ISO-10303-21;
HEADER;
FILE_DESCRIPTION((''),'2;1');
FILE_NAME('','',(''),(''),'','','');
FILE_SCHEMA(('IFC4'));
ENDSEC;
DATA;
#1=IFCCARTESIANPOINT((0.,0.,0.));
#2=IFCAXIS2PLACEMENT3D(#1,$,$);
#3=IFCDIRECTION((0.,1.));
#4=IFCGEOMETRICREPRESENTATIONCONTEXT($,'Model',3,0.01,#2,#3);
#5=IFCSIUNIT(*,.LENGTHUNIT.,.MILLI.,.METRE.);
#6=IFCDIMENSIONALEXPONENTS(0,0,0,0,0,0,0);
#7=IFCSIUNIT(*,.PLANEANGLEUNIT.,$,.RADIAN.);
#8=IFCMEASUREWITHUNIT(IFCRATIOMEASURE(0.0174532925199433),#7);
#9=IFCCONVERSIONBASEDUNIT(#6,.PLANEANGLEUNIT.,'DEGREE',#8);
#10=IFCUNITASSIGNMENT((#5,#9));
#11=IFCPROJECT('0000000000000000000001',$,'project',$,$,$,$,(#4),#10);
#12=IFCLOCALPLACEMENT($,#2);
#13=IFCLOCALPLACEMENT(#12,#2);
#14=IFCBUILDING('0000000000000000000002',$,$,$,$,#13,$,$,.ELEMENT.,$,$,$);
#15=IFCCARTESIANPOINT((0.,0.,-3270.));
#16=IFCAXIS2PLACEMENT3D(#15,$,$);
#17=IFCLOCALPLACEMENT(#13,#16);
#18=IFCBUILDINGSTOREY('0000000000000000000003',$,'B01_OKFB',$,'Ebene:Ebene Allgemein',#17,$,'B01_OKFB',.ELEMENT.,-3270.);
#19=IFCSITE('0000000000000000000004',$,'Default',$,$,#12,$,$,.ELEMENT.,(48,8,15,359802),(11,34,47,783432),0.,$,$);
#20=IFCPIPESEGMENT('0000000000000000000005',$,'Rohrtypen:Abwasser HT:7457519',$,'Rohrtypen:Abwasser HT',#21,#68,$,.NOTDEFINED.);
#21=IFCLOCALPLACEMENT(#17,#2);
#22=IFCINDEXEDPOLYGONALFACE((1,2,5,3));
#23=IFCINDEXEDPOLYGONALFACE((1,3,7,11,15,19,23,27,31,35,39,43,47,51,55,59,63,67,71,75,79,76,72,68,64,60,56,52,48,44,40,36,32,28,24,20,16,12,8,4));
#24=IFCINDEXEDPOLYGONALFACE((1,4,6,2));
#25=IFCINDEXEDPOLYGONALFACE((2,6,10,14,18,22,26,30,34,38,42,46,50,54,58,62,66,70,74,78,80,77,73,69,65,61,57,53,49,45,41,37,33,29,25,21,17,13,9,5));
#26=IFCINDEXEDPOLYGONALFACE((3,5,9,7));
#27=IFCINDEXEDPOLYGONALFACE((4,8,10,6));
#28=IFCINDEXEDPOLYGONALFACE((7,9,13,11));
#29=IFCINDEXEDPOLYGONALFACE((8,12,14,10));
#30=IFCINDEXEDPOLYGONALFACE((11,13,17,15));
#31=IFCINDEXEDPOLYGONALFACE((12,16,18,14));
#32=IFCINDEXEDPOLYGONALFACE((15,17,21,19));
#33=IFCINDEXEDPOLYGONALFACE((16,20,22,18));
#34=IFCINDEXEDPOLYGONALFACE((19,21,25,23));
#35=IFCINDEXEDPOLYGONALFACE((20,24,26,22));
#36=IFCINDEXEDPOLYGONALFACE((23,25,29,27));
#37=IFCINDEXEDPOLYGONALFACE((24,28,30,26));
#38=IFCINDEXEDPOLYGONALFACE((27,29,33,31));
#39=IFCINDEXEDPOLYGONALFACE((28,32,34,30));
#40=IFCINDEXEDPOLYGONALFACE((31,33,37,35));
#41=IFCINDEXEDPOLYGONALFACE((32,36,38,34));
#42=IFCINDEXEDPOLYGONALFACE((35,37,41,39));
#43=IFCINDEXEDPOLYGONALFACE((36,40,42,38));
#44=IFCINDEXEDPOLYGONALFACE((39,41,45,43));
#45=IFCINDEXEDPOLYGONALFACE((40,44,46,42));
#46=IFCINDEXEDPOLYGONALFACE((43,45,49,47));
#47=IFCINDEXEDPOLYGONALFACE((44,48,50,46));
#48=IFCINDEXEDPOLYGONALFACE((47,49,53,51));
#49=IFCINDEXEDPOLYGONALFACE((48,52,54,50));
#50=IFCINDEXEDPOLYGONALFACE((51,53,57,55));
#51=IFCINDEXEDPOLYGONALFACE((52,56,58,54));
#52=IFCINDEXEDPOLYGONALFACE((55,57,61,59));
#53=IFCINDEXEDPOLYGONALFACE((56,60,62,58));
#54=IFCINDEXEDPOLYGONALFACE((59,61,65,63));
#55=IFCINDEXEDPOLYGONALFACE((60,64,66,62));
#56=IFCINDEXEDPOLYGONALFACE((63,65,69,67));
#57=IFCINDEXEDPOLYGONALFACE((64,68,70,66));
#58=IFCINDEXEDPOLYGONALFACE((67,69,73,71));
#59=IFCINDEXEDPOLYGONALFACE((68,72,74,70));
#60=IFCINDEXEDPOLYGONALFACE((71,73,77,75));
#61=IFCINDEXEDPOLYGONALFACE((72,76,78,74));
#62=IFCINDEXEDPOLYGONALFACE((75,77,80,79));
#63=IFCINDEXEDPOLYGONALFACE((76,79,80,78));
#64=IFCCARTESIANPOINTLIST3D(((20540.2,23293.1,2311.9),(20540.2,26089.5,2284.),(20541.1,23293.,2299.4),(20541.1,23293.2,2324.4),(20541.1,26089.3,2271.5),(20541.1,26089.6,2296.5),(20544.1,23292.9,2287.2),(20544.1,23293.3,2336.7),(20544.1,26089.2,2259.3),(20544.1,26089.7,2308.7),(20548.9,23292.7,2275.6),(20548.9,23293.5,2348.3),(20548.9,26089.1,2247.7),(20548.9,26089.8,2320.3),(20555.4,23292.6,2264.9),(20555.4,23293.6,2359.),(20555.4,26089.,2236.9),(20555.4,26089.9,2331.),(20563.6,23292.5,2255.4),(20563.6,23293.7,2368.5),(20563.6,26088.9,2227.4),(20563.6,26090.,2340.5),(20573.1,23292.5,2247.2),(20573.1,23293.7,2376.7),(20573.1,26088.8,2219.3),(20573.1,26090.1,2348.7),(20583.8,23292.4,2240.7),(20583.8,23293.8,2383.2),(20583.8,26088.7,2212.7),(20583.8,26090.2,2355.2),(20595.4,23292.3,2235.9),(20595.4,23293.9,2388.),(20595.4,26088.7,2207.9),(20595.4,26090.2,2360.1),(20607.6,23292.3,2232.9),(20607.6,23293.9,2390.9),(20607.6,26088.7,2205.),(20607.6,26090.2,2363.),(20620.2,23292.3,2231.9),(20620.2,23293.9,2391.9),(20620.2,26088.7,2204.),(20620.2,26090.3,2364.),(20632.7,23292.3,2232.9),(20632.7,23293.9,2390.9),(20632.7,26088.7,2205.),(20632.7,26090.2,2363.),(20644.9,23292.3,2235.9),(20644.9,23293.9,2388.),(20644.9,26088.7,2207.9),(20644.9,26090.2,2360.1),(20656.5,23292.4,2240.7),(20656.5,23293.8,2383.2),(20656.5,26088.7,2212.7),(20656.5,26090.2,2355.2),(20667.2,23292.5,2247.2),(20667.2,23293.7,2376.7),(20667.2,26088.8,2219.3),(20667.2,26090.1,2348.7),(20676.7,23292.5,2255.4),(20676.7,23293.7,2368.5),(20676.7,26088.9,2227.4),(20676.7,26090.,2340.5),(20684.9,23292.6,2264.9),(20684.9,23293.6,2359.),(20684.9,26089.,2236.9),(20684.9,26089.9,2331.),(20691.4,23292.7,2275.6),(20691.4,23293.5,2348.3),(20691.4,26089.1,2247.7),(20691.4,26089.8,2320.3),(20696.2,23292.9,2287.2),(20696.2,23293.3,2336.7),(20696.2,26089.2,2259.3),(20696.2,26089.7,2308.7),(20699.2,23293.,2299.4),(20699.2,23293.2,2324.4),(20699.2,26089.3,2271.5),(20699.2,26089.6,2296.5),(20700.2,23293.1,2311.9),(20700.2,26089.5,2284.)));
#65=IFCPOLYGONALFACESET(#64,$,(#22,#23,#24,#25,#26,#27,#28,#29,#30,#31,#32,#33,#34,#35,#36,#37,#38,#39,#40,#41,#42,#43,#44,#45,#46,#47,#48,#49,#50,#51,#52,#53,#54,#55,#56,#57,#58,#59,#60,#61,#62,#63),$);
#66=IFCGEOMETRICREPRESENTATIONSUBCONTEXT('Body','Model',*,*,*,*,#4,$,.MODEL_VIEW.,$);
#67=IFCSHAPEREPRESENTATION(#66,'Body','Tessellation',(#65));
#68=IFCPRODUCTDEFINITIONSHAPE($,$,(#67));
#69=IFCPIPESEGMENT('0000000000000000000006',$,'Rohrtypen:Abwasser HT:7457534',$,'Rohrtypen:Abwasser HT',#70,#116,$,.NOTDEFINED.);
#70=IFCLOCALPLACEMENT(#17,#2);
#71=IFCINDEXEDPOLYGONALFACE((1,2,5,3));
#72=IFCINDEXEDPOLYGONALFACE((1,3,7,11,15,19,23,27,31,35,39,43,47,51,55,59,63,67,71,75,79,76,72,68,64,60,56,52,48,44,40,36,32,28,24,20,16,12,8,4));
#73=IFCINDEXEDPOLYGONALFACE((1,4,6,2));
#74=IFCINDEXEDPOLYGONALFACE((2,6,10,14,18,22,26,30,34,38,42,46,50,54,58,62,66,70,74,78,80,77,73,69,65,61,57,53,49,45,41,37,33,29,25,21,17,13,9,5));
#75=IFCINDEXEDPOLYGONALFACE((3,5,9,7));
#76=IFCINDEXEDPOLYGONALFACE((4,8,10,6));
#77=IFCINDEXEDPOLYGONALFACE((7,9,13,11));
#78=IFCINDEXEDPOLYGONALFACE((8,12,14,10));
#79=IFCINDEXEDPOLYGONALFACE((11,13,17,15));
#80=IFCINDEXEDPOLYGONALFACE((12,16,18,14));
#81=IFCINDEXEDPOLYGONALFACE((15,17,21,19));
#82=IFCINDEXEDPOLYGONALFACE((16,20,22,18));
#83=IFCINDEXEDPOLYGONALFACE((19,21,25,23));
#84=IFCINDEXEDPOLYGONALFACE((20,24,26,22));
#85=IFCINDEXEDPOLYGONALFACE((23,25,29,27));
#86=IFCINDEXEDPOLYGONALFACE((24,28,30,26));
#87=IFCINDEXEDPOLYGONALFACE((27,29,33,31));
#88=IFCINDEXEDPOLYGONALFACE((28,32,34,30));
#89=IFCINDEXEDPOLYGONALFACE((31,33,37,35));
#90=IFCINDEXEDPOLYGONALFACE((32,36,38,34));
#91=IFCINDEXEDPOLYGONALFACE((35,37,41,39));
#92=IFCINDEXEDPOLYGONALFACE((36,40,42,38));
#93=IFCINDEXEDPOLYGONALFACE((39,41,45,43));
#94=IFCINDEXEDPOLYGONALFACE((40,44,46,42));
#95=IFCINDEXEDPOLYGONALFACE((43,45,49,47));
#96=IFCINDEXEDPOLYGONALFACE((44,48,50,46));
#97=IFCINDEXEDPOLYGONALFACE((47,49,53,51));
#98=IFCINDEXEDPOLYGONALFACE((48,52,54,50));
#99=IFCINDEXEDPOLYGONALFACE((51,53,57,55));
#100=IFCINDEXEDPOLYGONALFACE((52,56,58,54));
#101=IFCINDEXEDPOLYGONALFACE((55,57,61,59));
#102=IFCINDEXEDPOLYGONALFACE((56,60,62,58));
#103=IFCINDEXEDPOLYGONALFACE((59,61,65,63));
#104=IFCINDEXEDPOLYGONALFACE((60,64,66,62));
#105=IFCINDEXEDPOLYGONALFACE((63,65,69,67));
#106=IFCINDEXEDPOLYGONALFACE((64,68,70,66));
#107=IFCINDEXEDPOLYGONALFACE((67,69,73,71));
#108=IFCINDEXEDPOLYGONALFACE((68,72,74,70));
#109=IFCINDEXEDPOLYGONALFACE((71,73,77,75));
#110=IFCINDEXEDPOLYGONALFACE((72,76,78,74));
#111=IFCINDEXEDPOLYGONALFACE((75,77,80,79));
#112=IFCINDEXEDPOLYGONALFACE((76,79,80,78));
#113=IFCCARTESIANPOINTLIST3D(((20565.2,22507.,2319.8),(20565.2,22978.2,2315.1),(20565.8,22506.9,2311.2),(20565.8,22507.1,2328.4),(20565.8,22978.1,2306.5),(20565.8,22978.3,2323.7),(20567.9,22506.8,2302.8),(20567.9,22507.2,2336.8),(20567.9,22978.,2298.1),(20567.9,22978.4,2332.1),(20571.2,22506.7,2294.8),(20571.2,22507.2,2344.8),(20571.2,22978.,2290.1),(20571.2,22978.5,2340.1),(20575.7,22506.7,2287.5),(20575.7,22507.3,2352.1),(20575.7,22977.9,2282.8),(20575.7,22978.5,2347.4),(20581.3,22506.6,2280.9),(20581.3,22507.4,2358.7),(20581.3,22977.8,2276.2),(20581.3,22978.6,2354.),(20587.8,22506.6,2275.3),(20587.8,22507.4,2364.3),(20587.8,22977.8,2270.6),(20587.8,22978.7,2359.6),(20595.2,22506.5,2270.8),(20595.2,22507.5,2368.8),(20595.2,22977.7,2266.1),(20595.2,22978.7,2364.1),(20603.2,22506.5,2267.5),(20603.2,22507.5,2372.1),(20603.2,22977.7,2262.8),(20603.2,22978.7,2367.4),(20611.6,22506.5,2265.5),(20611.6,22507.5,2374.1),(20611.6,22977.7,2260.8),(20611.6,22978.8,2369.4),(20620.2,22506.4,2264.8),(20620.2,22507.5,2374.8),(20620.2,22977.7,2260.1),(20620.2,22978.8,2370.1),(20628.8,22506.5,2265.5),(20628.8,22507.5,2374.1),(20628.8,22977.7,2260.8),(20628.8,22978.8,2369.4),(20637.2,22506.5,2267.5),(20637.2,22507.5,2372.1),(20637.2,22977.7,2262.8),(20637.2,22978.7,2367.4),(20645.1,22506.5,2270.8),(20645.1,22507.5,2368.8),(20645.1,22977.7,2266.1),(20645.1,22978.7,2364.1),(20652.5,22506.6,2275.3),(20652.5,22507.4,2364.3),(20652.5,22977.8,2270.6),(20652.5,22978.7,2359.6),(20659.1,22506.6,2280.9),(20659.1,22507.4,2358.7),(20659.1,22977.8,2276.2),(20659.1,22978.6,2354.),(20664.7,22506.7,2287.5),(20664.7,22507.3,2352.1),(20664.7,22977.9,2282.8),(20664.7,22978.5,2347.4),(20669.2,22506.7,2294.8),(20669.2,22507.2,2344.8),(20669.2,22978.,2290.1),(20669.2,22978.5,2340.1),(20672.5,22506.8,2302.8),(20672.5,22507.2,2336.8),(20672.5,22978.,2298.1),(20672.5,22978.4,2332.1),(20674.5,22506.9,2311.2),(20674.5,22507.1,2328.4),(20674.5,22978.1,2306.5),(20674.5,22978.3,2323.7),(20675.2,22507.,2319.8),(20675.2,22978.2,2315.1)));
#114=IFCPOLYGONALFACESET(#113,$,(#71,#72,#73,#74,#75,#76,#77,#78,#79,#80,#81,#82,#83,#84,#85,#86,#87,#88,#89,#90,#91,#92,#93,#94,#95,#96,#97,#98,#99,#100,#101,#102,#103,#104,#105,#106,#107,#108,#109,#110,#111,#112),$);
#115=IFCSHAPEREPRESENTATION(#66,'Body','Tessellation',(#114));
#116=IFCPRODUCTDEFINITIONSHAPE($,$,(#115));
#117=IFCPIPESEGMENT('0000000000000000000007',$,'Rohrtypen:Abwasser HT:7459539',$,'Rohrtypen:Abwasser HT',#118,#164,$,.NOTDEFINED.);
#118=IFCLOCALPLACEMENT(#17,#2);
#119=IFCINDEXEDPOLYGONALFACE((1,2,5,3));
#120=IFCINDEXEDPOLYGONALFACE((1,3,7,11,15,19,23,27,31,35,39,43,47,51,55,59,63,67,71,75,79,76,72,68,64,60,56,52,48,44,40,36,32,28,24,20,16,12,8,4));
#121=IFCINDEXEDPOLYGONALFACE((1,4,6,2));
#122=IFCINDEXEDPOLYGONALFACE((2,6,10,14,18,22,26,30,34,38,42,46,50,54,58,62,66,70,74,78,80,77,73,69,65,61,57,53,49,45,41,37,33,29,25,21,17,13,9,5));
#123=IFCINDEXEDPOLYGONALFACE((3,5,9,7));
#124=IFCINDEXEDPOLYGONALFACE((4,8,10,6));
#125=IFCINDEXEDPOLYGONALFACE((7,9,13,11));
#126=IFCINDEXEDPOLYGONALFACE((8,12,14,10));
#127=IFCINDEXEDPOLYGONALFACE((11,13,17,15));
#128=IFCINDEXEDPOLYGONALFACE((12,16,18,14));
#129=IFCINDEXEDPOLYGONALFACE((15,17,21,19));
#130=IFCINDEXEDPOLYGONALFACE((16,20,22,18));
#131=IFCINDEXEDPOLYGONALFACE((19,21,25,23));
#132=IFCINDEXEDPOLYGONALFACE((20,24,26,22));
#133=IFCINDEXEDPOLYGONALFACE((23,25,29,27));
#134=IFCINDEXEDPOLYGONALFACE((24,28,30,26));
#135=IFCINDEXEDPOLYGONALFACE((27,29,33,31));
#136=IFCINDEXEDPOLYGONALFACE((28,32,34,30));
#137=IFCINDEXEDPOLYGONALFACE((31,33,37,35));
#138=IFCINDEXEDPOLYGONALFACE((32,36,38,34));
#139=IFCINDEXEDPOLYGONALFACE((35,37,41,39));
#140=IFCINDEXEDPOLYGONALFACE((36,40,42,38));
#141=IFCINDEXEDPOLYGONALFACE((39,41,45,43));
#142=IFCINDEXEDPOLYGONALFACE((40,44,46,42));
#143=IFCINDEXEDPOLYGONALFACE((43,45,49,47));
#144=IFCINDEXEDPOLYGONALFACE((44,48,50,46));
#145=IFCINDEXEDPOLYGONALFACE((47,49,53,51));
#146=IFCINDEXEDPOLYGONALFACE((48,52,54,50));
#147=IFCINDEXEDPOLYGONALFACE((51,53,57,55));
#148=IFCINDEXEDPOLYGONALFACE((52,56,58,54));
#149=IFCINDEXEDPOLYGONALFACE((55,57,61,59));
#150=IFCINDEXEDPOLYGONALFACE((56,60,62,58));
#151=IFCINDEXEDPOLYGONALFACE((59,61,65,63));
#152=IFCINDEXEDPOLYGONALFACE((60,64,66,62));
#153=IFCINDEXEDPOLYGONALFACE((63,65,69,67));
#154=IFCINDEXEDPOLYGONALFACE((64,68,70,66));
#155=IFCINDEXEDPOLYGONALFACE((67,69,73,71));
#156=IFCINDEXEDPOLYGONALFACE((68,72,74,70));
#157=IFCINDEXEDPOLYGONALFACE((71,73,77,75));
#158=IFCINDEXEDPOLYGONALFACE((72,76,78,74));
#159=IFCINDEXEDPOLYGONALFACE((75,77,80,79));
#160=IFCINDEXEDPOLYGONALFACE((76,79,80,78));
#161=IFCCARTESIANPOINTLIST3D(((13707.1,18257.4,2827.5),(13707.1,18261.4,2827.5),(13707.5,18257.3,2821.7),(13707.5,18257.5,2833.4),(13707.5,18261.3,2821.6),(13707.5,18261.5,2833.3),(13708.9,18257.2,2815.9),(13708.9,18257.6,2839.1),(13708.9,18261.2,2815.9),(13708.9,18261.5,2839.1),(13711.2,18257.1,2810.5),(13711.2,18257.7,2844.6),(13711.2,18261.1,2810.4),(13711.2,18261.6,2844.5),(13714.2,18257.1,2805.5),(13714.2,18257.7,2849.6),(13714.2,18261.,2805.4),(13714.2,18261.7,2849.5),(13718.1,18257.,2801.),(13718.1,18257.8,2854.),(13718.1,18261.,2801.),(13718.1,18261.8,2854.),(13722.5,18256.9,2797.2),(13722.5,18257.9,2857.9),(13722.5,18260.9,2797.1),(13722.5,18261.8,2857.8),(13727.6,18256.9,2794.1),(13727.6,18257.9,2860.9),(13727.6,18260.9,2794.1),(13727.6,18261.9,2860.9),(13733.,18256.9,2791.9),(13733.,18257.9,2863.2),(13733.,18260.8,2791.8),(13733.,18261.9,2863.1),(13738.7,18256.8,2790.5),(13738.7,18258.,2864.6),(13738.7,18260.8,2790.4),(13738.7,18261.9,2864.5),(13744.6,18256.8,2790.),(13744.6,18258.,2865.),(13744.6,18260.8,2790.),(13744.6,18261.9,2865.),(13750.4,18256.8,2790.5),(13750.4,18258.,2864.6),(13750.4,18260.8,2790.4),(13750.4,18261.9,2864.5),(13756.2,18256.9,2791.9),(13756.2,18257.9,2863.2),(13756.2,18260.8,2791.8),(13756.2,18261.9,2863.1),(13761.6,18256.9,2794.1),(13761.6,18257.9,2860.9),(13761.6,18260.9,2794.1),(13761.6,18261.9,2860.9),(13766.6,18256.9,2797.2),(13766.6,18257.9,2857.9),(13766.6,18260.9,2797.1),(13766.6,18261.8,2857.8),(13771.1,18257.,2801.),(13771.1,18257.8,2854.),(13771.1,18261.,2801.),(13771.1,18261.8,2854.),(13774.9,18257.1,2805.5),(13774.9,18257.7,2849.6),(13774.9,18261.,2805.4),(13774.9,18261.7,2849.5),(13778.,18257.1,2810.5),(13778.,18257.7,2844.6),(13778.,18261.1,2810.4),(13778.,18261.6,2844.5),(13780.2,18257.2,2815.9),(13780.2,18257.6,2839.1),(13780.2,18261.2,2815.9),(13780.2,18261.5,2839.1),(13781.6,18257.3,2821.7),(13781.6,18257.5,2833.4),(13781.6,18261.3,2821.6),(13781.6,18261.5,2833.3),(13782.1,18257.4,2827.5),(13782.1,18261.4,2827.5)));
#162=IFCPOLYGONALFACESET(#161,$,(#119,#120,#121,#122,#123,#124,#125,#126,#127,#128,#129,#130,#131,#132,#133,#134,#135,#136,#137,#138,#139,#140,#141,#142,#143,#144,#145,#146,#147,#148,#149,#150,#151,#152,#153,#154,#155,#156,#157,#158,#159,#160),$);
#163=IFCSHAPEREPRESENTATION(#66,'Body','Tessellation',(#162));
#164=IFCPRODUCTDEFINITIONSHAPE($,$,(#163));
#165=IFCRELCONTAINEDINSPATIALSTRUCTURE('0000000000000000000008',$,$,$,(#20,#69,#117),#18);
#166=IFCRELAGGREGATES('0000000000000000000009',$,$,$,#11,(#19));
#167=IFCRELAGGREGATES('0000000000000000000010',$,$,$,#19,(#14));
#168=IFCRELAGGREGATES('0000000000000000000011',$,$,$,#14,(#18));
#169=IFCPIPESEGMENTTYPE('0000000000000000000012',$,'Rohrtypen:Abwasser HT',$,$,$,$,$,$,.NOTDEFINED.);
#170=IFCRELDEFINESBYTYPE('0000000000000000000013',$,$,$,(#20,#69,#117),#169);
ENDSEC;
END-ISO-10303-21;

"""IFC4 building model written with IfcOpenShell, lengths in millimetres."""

from ifc_helpers import new_model, entity, si_unit, converted_unit, direction, frame, origin, place, context, subcontext, project, spatial, indexed_curve, outline, extrude, type_object, element, save


model = new_model("IFC4")

# Units and contexts
model_context = context("Model", 3, precision=0.01, world=origin(), true_north=direction((0.0, 1.0)))
body_context = subcontext(model_context, "Body", "Model", "MODEL_VIEW")
ifc_project = project(units=[si_unit("LENGTHUNIT", "METRE", prefix="MILLI"), converted_unit("PLANEANGLEUNIT", "DEGREE", entity("IfcRatioMeasure", 0.0174532925199433), si_unit("PLANEANGLEUNIT", "RADIAN"), dimensions=[0, 0, 0, 0, 0, 0, 0])], contexts=[model_context])

# Site, building, storey
site_placement = place(None, origin())
site = spatial("IfcSite", under=ifc_project, at=site_placement, Name="Default", CompositionType="ELEMENT", RefLatitude=(48, 8, 15, 359802), RefLongitude=(11, 34, 47, 783432), RefElevation=0.0)
building_placement = place(site_placement, origin())
building = spatial("IfcBuilding", under=site, at=building_placement, CompositionType="ELEMENT")
storey_placement = place(building_placement, frame((0.0, 0.0, -3270.0)))
storey = spatial("IfcBuildingStorey", under=building, at=storey_placement, Name="B01_OKFB", ObjectType="Ebene:Ebene Allgemein", LongName="B01_OKFB", CompositionType="ELEMENT", Elevation=-3270.0)

# Pipe segments
pipe_segment_type_1 = type_object("IfcPipeSegmentType", Name="Rohrtypen:Abwasser HT", PredefinedType="NOTDEFINED")
pipe_segment_1_placement = place(storey_placement, origin())
element("IfcPipeSegment", 1, at=pipe_segment_1_placement, inside=storey, type_object=pipe_segment_type_1, Name="Rohrtypen:Abwasser HT:7457519", ObjectType="Rohrtypen:Abwasser HT", PredefinedType="NOTDEFINED", context=body_context, shape_type="SweptSolid", body=[
    extrude(outline(indexed_curve([(80.0, 0.0), (79.0, 12.5), (76.1, 24.7), (71.3, 36.3), (64.7, 47.0), (56.6, 56.6), (47.0, 64.7), (36.3, 71.3), (24.7, 76.1), (12.5, 79.0), (0.0, 80.0), (-12.5, 79.0), (-24.7, 76.1), (-36.3, 71.3), (-47.0, 64.7), (-56.6, 56.6), (-64.7, 47.0), (-71.3, 36.3), (-76.1, 24.7), (-79.0, 12.5), (-80.0, 0.0), (-79.0, -12.5), (-76.1, -24.7), (-71.3, -36.3), (-64.7, -47.0), (-56.6, -56.6), (-47.0, -64.7), (-36.3, -71.3), (-24.7, -76.1), (-12.5, -79.0), (0.0, -80.0), (12.5, -79.0), (24.7, -76.1), (36.3, -71.3), (47.0, -64.7), (56.6, -56.6), (64.7, -47.0), (71.3, -36.3), (76.1, -24.7), (79.0, -12.5), (80.0, 0.0)], self_intersect=False)), frame((20620.2, 23293.1, 2311.9), z_axis=(0.000001, 0.99995, -0.01), x_axis=(1.0, -0.000001, 0.0)), (0.0, 0.0, 1.0), 2796.5),
])
pipe_segment_2_placement = place(storey_placement, origin())
element("IfcPipeSegment", 2, at=pipe_segment_2_placement, inside=storey, type_object=pipe_segment_type_1, Name="Rohrtypen:Abwasser HT:7457534", ObjectType="Rohrtypen:Abwasser HT", PredefinedType="NOTDEFINED", context=body_context, shape_type="SweptSolid", body=[
    extrude(outline(indexed_curve([(55.0, 0.0), (54.3, 8.6), (52.3, 17.0), (49.0, 25.0), (44.5, 32.3), (38.9, 38.9), (32.3, 44.5), (25.0, 49.0), (17.0, 52.3), (8.6, 54.3), (0.0, 55.0), (-8.6, 54.3), (-17.0, 52.3), (-25.0, 49.0), (-32.3, 44.5), (-38.9, 38.9), (-44.5, 32.3), (-49.0, 25.0), (-52.3, 17.0), (-54.3, 8.6), (-55.0, 0.0), (-54.3, -8.6), (-52.3, -17.0), (-49.0, -25.0), (-44.5, -32.3), (-38.9, -38.9), (-32.3, -44.5), (-25.0, -49.0), (-17.0, -52.3), (-8.6, -54.3), (0.0, -55.0), (8.6, -54.3), (17.0, -52.3), (25.0, -49.0), (32.3, -44.5), (38.9, -38.9), (44.5, -32.3), (49.0, -25.0), (52.3, -17.0), (54.3, -8.6), (55.0, 0.0)], self_intersect=False)), frame((20620.2, 22978.2, 2315.1), z_axis=(0.0, -0.99995, 0.01), x_axis=(1.0, 0.0, 0.0)), (0.0, 0.0, 1.0), 471.2),
])
pipe_segment_3_placement = place(storey_placement, origin())
element("IfcPipeSegment", 3, at=pipe_segment_3_placement, inside=storey, type_object=pipe_segment_type_1, Name="Rohrtypen:Abwasser HT:7459539", ObjectType="Rohrtypen:Abwasser HT", PredefinedType="NOTDEFINED", context=body_context, shape_type="SweptSolid", body=[
    extrude(outline(indexed_curve([(37.5, 0.0), (37.0, 5.9), (35.7, 11.6), (33.4, 17.0), (30.3, 22.0), (26.5, 26.5), (22.0, 30.3), (17.0, 33.4), (11.6, 35.7), (5.9, 37.0), (0.0, 37.5), (-5.9, 37.0), (-11.6, 35.7), (-17.0, 33.4), (-22.0, 30.3), (-26.5, 26.5), (-30.3, 22.0), (-33.4, 17.0), (-35.7, 11.6), (-37.0, 5.9), (-37.5, 0.0), (-37.0, -5.9), (-35.7, -11.6), (-33.4, -17.0), (-30.3, -22.0), (-26.5, -26.5), (-22.0, -30.3), (-17.0, -33.4), (-11.6, -35.7), (-5.9, -37.0), (0.0, -37.5), (5.9, -37.0), (11.6, -35.7), (17.0, -33.4), (22.0, -30.3), (26.5, -26.5), (30.3, -22.0), (33.4, -17.0), (35.7, -11.6), (37.0, -5.9), (37.5, 0.0)], self_intersect=False)), frame((13744.6, 18257.4, 2827.5), z_axis=(0.0, 0.999888, -0.014998), x_axis=(1.0, 0.0, 0.0)), (0.0, 0.0, 1.0), 4.0),
])

save(model, "model.ifc")
